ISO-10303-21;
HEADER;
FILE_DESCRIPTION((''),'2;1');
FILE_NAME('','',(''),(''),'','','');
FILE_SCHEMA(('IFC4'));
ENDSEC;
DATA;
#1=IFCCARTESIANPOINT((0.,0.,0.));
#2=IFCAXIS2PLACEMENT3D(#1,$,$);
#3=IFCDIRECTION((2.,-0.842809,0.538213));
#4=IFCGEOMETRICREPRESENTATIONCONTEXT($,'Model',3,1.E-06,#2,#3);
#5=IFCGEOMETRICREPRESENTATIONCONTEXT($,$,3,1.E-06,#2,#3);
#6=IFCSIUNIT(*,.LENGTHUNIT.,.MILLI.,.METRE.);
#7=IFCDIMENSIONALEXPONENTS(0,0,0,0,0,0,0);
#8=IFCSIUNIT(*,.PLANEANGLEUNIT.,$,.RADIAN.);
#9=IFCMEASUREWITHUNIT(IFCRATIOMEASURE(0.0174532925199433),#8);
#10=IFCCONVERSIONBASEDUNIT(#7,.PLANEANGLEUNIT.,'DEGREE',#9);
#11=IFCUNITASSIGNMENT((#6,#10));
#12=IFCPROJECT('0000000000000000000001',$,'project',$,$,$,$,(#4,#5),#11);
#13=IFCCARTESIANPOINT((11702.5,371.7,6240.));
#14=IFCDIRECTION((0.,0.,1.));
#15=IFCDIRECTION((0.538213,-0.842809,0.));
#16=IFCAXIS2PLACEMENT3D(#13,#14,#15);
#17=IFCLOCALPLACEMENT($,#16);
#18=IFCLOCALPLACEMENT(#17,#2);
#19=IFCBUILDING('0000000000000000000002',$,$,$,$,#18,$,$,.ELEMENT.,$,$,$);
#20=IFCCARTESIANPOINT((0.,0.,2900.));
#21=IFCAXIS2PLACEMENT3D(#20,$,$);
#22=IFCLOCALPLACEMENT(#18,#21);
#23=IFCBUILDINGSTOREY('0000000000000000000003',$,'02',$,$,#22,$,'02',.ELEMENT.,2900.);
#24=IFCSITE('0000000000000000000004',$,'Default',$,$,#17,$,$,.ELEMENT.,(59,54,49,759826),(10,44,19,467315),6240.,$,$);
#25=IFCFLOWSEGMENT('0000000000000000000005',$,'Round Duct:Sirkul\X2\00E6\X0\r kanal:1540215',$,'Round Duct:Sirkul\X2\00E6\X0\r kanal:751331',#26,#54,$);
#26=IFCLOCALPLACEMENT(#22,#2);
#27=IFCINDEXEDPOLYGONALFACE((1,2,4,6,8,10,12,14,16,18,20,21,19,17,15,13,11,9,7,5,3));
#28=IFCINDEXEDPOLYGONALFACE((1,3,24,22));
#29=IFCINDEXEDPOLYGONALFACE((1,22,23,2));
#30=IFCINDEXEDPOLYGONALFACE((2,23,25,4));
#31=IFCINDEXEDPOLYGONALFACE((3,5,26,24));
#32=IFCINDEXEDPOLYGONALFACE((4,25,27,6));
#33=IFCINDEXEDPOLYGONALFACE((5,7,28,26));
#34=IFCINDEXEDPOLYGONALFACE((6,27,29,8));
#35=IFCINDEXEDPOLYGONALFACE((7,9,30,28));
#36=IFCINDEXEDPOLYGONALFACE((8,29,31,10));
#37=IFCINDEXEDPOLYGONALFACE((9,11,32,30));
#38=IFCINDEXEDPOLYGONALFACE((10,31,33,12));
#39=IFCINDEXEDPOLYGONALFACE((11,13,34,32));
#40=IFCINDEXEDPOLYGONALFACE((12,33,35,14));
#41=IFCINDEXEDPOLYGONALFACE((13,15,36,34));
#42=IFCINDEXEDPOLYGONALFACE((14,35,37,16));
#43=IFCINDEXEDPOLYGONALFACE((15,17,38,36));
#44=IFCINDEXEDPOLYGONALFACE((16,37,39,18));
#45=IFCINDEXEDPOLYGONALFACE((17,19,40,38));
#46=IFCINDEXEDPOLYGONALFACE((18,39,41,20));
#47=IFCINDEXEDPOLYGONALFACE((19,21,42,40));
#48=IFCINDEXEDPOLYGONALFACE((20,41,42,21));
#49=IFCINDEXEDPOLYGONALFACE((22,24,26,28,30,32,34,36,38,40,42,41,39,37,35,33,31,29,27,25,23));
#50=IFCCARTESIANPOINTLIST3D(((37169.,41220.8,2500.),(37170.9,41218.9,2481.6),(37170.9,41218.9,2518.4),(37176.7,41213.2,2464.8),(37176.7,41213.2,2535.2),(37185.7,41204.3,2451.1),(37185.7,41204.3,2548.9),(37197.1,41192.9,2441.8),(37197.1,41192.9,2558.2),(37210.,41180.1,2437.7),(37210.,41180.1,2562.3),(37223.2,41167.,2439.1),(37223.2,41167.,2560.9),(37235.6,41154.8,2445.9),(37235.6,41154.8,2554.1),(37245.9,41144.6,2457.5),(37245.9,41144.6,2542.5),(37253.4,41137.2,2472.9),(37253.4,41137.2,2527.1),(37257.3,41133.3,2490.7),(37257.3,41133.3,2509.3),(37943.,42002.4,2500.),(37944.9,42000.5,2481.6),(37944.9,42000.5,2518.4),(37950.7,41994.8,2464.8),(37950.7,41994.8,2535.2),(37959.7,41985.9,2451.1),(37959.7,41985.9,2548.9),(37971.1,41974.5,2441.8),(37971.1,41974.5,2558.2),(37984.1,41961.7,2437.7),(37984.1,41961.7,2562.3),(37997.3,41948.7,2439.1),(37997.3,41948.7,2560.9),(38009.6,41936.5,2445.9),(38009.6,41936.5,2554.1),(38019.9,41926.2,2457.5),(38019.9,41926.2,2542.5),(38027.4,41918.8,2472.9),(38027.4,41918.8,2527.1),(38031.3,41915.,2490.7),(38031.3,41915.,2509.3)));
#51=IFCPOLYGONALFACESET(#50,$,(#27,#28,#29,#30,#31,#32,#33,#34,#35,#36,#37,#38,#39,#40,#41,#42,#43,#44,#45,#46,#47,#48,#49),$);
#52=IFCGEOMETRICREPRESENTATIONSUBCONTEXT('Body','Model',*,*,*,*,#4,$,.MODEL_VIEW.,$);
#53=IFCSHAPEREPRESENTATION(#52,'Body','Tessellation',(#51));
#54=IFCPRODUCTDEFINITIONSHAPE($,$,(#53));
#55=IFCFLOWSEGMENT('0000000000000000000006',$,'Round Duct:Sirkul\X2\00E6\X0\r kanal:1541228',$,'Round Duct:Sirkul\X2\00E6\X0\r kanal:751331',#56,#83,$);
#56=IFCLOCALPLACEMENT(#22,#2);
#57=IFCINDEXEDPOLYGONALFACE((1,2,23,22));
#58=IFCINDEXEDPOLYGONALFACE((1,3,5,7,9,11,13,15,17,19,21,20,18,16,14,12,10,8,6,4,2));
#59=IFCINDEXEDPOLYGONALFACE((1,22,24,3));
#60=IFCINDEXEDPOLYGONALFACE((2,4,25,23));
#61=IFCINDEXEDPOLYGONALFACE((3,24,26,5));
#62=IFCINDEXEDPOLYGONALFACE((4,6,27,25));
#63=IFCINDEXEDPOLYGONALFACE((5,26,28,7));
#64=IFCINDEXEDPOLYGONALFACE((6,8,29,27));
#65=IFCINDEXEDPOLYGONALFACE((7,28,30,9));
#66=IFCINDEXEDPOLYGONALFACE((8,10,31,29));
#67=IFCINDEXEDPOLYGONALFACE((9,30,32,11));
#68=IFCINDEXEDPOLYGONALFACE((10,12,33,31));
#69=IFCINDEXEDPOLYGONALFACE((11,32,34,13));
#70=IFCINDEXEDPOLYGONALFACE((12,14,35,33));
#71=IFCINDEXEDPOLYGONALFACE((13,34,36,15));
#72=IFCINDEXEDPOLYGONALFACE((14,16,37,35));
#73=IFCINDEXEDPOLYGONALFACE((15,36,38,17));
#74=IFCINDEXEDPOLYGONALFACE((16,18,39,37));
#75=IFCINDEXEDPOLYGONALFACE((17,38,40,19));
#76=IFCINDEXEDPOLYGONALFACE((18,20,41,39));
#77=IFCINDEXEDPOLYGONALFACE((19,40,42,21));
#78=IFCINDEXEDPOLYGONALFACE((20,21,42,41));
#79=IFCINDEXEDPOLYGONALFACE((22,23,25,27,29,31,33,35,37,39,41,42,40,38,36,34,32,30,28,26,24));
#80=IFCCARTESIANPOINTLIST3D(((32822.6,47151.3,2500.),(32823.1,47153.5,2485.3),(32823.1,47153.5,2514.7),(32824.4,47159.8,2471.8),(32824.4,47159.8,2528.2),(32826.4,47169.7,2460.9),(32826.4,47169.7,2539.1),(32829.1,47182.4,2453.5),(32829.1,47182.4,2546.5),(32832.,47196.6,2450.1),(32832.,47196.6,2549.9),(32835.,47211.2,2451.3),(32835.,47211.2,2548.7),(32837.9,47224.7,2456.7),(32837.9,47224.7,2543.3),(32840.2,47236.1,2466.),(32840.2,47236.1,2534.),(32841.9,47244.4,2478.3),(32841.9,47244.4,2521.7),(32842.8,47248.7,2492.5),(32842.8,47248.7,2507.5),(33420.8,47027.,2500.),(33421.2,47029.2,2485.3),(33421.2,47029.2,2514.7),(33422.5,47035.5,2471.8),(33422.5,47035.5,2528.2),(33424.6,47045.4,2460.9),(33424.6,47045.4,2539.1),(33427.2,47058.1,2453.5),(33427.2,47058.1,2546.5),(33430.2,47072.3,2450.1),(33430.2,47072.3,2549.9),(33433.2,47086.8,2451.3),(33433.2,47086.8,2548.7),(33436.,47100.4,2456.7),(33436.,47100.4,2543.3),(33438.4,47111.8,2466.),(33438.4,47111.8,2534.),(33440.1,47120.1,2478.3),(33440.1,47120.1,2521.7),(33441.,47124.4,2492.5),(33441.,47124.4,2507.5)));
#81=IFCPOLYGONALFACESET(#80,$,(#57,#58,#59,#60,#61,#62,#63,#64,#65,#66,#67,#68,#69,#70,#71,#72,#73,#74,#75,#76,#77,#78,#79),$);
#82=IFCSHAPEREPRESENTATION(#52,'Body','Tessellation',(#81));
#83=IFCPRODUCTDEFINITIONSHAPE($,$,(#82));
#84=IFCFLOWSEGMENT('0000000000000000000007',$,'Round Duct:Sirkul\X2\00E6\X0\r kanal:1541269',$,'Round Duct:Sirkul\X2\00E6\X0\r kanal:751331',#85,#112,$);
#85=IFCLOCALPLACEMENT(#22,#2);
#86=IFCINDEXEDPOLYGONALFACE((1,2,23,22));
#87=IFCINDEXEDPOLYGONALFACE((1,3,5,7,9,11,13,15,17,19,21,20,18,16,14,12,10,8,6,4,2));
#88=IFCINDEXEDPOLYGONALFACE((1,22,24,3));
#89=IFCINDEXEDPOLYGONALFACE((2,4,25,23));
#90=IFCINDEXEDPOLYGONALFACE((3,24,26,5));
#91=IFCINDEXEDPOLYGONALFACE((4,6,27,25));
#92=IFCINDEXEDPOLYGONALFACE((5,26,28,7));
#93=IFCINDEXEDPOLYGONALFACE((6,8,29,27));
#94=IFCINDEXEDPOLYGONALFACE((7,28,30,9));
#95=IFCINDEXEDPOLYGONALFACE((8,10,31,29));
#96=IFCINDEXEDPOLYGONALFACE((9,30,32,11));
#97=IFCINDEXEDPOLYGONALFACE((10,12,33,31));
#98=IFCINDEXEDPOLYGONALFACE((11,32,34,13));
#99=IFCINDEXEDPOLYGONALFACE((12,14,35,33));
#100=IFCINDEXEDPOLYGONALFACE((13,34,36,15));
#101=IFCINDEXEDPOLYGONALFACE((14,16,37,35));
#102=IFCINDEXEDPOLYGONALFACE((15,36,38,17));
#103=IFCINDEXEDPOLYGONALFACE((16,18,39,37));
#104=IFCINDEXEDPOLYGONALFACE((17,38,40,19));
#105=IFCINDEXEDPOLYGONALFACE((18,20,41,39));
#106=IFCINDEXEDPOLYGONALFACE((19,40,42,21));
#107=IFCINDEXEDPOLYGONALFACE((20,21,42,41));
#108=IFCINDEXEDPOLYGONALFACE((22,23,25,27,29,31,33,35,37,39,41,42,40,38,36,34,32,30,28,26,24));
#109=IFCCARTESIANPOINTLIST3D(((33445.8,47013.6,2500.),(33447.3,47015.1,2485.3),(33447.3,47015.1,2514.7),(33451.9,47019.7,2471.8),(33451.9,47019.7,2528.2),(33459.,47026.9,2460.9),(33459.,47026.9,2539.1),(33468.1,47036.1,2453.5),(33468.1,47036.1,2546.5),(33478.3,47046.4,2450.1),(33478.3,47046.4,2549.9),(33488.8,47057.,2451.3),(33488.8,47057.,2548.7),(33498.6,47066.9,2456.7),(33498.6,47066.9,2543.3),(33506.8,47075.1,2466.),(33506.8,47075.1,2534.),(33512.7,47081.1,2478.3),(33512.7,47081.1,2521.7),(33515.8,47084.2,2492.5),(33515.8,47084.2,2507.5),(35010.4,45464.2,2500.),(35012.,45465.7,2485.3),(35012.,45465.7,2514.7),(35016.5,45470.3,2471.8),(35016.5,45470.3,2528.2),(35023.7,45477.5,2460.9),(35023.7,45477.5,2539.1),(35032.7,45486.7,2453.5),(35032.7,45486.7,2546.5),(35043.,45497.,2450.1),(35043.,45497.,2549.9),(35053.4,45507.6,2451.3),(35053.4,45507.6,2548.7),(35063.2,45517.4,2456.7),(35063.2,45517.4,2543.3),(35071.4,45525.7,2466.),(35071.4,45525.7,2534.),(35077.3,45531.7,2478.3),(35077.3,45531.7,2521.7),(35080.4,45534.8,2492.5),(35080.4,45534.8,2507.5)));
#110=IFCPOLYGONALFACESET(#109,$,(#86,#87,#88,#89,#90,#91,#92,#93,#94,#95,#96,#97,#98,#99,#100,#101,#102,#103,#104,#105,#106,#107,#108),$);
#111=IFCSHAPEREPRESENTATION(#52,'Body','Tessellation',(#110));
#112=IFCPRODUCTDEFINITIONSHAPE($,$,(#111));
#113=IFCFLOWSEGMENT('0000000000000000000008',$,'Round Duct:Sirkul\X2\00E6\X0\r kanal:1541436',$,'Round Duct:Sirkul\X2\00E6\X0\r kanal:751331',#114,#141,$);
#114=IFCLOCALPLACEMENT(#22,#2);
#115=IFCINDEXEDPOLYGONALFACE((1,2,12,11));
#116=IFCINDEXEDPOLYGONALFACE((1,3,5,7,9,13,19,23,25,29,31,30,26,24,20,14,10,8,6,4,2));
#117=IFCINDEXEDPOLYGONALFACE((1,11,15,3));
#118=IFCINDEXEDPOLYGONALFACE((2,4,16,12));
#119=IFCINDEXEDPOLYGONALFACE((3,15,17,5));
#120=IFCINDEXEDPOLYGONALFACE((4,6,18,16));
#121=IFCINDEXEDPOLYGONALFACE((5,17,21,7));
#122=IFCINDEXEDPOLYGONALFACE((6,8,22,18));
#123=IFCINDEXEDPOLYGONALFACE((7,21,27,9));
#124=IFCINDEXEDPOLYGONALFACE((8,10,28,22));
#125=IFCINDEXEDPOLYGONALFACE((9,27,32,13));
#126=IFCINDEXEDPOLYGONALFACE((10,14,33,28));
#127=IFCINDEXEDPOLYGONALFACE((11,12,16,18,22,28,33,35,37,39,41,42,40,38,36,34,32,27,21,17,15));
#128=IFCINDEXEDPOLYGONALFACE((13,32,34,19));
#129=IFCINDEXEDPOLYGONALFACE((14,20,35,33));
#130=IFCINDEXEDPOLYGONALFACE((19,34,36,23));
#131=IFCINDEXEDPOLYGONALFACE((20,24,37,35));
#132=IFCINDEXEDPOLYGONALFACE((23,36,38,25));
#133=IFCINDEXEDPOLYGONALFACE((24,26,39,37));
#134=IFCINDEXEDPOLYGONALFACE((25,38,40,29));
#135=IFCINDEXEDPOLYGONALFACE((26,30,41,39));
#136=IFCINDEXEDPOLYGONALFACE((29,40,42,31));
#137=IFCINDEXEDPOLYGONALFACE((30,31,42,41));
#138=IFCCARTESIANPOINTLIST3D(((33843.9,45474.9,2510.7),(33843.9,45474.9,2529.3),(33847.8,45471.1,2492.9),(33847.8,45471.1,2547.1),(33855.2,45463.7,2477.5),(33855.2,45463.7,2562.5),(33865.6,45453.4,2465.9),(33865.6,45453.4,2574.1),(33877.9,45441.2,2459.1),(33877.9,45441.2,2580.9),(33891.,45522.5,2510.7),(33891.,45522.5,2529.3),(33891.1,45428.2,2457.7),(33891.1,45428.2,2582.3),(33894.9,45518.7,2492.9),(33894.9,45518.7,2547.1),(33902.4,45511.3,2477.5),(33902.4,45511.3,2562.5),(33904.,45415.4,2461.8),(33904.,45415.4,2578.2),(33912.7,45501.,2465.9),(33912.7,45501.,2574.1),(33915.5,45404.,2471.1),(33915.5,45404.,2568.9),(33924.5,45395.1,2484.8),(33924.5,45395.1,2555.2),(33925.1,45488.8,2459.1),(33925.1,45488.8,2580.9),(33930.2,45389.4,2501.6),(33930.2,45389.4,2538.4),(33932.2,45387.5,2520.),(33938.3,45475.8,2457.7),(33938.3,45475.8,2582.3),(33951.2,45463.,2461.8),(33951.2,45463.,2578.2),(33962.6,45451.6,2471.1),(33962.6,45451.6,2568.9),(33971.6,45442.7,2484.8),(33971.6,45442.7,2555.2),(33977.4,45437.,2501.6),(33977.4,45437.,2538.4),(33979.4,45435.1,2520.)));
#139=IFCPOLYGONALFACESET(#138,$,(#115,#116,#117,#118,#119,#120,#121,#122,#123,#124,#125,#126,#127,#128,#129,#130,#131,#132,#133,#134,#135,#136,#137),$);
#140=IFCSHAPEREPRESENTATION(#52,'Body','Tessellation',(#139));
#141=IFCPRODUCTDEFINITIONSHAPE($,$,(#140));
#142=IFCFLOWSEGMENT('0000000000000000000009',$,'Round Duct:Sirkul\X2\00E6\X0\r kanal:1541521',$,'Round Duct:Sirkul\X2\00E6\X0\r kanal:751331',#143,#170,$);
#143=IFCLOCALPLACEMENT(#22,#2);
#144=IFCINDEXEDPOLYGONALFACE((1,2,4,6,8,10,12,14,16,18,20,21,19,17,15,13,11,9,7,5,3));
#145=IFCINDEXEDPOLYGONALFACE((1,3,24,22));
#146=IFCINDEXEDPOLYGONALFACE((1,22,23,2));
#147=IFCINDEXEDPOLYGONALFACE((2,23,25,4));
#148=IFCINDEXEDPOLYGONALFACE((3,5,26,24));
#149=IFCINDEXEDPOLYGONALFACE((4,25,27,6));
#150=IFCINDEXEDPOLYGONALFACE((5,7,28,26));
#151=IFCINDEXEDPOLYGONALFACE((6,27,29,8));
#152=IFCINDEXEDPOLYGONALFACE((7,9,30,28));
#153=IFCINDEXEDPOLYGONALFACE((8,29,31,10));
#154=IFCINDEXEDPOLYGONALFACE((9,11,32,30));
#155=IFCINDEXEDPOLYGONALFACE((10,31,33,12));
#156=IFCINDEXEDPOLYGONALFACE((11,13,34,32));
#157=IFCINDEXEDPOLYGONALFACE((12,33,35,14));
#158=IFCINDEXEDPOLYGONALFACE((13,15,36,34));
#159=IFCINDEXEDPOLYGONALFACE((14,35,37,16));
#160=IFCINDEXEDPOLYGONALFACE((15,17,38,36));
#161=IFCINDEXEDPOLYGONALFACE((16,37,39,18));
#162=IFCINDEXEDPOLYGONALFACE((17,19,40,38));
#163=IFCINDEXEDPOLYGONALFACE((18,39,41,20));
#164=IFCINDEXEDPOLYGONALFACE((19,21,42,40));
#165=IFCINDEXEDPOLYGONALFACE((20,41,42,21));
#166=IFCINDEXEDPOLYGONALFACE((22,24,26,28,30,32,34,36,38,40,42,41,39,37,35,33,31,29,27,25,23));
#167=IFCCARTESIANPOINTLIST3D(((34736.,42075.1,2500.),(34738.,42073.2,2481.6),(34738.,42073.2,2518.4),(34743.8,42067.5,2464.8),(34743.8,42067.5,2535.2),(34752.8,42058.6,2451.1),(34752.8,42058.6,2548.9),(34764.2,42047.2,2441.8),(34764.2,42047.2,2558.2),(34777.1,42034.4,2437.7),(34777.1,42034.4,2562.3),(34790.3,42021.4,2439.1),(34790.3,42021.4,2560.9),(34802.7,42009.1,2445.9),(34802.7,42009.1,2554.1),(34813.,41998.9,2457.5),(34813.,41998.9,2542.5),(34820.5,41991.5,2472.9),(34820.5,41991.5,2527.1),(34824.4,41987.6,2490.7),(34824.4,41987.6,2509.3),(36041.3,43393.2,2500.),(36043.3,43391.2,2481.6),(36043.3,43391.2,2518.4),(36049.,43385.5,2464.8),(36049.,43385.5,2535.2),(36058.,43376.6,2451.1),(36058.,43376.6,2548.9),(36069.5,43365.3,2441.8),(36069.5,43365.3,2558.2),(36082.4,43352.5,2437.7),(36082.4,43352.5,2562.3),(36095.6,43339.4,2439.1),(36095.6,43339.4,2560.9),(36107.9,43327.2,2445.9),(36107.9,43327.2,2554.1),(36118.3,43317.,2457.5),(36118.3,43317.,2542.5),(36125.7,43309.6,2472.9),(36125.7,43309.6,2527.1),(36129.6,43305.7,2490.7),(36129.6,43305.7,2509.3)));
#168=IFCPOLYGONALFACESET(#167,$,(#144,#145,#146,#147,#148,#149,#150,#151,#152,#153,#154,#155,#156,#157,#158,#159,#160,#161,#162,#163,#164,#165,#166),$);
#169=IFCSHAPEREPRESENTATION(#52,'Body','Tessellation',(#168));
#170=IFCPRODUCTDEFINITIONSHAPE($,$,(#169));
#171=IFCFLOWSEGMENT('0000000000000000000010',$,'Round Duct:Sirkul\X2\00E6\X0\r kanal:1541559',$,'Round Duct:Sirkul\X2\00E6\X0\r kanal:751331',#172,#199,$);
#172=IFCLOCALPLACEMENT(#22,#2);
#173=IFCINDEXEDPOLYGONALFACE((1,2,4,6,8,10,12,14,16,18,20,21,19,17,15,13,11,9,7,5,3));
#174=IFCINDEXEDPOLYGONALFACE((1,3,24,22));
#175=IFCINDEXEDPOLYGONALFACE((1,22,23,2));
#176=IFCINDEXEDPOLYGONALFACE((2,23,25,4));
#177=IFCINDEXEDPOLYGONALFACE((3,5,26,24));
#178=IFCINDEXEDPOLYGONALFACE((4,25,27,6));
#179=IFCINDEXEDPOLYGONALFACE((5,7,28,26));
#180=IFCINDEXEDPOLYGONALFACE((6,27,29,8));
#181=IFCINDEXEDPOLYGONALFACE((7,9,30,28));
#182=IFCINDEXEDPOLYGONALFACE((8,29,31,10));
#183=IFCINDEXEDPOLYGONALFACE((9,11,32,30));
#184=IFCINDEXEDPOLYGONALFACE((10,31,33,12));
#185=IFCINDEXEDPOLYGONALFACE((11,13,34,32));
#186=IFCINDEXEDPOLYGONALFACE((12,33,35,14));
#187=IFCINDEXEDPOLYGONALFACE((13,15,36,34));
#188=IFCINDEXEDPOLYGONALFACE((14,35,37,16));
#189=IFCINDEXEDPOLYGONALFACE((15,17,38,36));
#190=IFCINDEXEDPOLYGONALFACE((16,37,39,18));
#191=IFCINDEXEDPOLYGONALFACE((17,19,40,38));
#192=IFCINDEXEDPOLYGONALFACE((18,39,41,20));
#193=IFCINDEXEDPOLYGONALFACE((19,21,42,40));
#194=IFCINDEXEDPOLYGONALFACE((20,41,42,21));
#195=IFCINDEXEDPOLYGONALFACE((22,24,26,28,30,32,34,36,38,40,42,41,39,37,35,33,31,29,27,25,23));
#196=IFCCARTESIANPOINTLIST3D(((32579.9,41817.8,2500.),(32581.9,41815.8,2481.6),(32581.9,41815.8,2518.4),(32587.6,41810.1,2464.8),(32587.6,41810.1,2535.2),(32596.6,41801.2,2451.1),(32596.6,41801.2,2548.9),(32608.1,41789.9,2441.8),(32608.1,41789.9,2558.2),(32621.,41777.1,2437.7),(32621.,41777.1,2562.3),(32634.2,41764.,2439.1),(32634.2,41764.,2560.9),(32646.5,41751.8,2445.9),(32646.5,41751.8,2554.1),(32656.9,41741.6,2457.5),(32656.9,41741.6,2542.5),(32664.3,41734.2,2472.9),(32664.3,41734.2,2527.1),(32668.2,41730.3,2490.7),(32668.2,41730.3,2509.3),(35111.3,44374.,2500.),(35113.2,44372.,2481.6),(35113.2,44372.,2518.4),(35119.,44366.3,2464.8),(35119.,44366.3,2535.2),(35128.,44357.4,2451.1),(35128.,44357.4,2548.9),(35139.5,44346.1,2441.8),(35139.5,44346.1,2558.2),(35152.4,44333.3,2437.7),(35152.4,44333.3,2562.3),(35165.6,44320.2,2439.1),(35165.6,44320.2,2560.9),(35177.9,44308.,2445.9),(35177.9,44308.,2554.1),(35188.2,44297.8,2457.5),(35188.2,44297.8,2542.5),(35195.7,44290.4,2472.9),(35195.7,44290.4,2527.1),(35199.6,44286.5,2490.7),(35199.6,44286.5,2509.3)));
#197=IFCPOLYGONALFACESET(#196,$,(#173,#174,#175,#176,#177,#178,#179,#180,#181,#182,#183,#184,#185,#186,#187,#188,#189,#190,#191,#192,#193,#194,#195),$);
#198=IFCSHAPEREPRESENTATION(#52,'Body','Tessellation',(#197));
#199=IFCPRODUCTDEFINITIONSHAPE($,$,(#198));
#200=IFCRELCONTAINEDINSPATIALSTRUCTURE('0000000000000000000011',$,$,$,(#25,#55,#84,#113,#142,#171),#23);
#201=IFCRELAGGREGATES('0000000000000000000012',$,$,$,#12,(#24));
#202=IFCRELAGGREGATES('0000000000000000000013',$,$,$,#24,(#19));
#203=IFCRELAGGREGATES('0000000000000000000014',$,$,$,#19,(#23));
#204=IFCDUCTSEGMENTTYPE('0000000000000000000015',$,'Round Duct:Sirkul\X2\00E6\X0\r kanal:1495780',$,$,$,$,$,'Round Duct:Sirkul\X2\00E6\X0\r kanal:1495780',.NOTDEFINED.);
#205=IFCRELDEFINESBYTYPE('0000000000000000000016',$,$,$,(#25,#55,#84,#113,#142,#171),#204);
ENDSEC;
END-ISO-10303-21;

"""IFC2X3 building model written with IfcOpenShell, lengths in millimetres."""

from ifc_helpers import new_model, entity, si_unit, converted_unit, direction, frame, origin, origin_2d_with_axis, place, context, subcontext, project, spatial, circle, extrude, type_object, element, save


model = new_model("IFC2X3")

# Units and contexts
model_context = context("Model", 3, precision=1e-06, world=origin(), true_north=direction((2.0, -0.842809, 0.538213)))
context_of_model = context(None, 3, precision=1e-06, world=origin(), true_north=direction((2.0, -0.842809, 0.538213)))
body_context = subcontext(model_context, "Body", "Model", "MODEL_VIEW")
ifc_project = project(units=[si_unit("LENGTHUNIT", "METRE", prefix="MILLI"), converted_unit("PLANEANGLEUNIT", "DEGREE", entity("IfcRatioMeasure", 0.0174532925199433), si_unit("PLANEANGLEUNIT", "RADIAN"), dimensions=[0, 0, 0, 0, 0, 0, 0])], contexts=[model_context, context_of_model])

# Site, building, storey
site_placement = place(None, frame((11702.5, 371.7, 6240.0), z_axis=(0.0, 0.0, 1.0), x_axis=(0.538213, -0.842809, 0.0)))
site = spatial("IfcSite", under=ifc_project, at=site_placement, Name="Default", CompositionType="ELEMENT", RefLatitude=(59, 54, 49, 759826), RefLongitude=(10, 44, 19, 467315), RefElevation=6240.0)
building_placement = place(site_placement, origin())
building = spatial("IfcBuilding", under=site, at=building_placement, CompositionType="ELEMENT")
storey_placement = place(building_placement, frame((0.0, 0.0, 2900.0)))
storey = spatial("IfcBuildingStorey", under=building, at=storey_placement, Name="02", LongName="02", CompositionType="ELEMENT", Elevation=2900.0)

# Flow segments
duct_segment_type_1 = type_object("IfcDuctSegmentType", Name="Round Duct:Sirkulær kanal:1495780", ElementType="Round Duct:Sirkulær kanal:1495780", PredefinedType="NOTDEFINED")
flow_segment_1_placement = place(storey_placement, origin())
element("IfcFlowSegment", 1, at=flow_segment_1_placement, inside=storey, type_object=duct_segment_type_1, Name="Round Duct:Sirkulær kanal:1540215", ObjectType="Round Duct:Sirkulær kanal:751331", context=body_context, shape_type="SweptSolid", body=[
    extrude(circle(Radius=62.5, at=origin_2d_with_axis()), frame((37213.4, 41176.8, 2500.0), z_axis=(0.703643, 0.710554, 0.0), x_axis=(-0.710554, 0.703643, 0.0)), (0.0, 0.0, 1.0), 1100.0),
])
flow_segment_2_placement = place(storey_placement, origin())
element("IfcFlowSegment", 2, at=flow_segment_2_placement, inside=storey, type_object=duct_segment_type_1, Name="Round Duct:Sirkulær kanal:1541228", ObjectType="Round Duct:Sirkulær kanal:751331", context=body_context, shape_type="SweptSolid", body=[
    extrude(circle(Radius=50.0, at=origin_2d_with_axis()), frame((32832.8, 47200.3, 2500.0), z_axis=(0.979081, -0.203471, 0.0), x_axis=(-0.203471, -0.979081, 0.0)), (0.0, 0.0, 1.0), 610.9),
])
flow_segment_3_placement = place(storey_placement, origin())
element("IfcFlowSegment", 3, at=flow_segment_3_placement, inside=storey, type_object=duct_segment_type_1, Name="Round Duct:Sirkulær kanal:1541269", ObjectType="Round Duct:Sirkulær kanal:751331", context=body_context, shape_type="SweptSolid", body=[
    extrude(circle(Radius=50.0, at=origin_2d_with_axis()), frame((35045.6, 45499.7, 2500.0), z_axis=(-0.710554, 0.703643, 0.0), x_axis=(-0.703643, -0.710554, 0.0)), (0.0, 0.0, 1.0), 2202.0),
])
flow_segment_4_placement = place(storey_placement, origin())
element("IfcFlowSegment", 4, at=flow_segment_4_placement, inside=storey, type_object=duct_segment_type_1, Name="Round Duct:Sirkulær kanal:1541436", ObjectType="Round Duct:Sirkulær kanal:751331", context=body_context, shape_type="SweptSolid", body=[
    extrude(circle(Radius=62.5, at=origin_2d_with_axis()), frame((33887.8, 45431.4, 2520.0), z_axis=(0.703643, 0.710554, 0.0), x_axis=(0.710554, -0.703643, 0.0)), (0.0, 0.0, 1.0), 67.0),
])
flow_segment_5_placement = place(storey_placement, origin())
element("IfcFlowSegment", 5, at=flow_segment_5_placement, inside=storey, type_object=duct_segment_type_1, Name="Round Duct:Sirkulær kanal:1541521", ObjectType="Round Duct:Sirkulær kanal:751331", context=body_context, shape_type="SweptSolid", body=[
    extrude(circle(Radius=62.5, at=origin_2d_with_axis()), frame((34780.4, 42031.1, 2500.0), z_axis=(0.703643, 0.710554, 0.0), x_axis=(-0.710554, 0.703643, 0.0)), (0.0, 0.0, 1.0), 1855.0),
])
flow_segment_6_placement = place(storey_placement, origin())
element("IfcFlowSegment", 6, at=flow_segment_6_placement, inside=storey, type_object=duct_segment_type_1, Name="Round Duct:Sirkulær kanal:1541559", ObjectType="Round Duct:Sirkulær kanal:751331", context=body_context, shape_type="SweptSolid", body=[
    extrude(circle(Radius=62.5, at=origin_2d_with_axis()), frame((32624.3, 41773.8, 2500.0), z_axis=(0.703643, 0.710554, 0.0), x_axis=(-0.710554, 0.703643, 0.0)), (0.0, 0.0, 1.0), 3597.5),
])

save(model, "model.ifc")
